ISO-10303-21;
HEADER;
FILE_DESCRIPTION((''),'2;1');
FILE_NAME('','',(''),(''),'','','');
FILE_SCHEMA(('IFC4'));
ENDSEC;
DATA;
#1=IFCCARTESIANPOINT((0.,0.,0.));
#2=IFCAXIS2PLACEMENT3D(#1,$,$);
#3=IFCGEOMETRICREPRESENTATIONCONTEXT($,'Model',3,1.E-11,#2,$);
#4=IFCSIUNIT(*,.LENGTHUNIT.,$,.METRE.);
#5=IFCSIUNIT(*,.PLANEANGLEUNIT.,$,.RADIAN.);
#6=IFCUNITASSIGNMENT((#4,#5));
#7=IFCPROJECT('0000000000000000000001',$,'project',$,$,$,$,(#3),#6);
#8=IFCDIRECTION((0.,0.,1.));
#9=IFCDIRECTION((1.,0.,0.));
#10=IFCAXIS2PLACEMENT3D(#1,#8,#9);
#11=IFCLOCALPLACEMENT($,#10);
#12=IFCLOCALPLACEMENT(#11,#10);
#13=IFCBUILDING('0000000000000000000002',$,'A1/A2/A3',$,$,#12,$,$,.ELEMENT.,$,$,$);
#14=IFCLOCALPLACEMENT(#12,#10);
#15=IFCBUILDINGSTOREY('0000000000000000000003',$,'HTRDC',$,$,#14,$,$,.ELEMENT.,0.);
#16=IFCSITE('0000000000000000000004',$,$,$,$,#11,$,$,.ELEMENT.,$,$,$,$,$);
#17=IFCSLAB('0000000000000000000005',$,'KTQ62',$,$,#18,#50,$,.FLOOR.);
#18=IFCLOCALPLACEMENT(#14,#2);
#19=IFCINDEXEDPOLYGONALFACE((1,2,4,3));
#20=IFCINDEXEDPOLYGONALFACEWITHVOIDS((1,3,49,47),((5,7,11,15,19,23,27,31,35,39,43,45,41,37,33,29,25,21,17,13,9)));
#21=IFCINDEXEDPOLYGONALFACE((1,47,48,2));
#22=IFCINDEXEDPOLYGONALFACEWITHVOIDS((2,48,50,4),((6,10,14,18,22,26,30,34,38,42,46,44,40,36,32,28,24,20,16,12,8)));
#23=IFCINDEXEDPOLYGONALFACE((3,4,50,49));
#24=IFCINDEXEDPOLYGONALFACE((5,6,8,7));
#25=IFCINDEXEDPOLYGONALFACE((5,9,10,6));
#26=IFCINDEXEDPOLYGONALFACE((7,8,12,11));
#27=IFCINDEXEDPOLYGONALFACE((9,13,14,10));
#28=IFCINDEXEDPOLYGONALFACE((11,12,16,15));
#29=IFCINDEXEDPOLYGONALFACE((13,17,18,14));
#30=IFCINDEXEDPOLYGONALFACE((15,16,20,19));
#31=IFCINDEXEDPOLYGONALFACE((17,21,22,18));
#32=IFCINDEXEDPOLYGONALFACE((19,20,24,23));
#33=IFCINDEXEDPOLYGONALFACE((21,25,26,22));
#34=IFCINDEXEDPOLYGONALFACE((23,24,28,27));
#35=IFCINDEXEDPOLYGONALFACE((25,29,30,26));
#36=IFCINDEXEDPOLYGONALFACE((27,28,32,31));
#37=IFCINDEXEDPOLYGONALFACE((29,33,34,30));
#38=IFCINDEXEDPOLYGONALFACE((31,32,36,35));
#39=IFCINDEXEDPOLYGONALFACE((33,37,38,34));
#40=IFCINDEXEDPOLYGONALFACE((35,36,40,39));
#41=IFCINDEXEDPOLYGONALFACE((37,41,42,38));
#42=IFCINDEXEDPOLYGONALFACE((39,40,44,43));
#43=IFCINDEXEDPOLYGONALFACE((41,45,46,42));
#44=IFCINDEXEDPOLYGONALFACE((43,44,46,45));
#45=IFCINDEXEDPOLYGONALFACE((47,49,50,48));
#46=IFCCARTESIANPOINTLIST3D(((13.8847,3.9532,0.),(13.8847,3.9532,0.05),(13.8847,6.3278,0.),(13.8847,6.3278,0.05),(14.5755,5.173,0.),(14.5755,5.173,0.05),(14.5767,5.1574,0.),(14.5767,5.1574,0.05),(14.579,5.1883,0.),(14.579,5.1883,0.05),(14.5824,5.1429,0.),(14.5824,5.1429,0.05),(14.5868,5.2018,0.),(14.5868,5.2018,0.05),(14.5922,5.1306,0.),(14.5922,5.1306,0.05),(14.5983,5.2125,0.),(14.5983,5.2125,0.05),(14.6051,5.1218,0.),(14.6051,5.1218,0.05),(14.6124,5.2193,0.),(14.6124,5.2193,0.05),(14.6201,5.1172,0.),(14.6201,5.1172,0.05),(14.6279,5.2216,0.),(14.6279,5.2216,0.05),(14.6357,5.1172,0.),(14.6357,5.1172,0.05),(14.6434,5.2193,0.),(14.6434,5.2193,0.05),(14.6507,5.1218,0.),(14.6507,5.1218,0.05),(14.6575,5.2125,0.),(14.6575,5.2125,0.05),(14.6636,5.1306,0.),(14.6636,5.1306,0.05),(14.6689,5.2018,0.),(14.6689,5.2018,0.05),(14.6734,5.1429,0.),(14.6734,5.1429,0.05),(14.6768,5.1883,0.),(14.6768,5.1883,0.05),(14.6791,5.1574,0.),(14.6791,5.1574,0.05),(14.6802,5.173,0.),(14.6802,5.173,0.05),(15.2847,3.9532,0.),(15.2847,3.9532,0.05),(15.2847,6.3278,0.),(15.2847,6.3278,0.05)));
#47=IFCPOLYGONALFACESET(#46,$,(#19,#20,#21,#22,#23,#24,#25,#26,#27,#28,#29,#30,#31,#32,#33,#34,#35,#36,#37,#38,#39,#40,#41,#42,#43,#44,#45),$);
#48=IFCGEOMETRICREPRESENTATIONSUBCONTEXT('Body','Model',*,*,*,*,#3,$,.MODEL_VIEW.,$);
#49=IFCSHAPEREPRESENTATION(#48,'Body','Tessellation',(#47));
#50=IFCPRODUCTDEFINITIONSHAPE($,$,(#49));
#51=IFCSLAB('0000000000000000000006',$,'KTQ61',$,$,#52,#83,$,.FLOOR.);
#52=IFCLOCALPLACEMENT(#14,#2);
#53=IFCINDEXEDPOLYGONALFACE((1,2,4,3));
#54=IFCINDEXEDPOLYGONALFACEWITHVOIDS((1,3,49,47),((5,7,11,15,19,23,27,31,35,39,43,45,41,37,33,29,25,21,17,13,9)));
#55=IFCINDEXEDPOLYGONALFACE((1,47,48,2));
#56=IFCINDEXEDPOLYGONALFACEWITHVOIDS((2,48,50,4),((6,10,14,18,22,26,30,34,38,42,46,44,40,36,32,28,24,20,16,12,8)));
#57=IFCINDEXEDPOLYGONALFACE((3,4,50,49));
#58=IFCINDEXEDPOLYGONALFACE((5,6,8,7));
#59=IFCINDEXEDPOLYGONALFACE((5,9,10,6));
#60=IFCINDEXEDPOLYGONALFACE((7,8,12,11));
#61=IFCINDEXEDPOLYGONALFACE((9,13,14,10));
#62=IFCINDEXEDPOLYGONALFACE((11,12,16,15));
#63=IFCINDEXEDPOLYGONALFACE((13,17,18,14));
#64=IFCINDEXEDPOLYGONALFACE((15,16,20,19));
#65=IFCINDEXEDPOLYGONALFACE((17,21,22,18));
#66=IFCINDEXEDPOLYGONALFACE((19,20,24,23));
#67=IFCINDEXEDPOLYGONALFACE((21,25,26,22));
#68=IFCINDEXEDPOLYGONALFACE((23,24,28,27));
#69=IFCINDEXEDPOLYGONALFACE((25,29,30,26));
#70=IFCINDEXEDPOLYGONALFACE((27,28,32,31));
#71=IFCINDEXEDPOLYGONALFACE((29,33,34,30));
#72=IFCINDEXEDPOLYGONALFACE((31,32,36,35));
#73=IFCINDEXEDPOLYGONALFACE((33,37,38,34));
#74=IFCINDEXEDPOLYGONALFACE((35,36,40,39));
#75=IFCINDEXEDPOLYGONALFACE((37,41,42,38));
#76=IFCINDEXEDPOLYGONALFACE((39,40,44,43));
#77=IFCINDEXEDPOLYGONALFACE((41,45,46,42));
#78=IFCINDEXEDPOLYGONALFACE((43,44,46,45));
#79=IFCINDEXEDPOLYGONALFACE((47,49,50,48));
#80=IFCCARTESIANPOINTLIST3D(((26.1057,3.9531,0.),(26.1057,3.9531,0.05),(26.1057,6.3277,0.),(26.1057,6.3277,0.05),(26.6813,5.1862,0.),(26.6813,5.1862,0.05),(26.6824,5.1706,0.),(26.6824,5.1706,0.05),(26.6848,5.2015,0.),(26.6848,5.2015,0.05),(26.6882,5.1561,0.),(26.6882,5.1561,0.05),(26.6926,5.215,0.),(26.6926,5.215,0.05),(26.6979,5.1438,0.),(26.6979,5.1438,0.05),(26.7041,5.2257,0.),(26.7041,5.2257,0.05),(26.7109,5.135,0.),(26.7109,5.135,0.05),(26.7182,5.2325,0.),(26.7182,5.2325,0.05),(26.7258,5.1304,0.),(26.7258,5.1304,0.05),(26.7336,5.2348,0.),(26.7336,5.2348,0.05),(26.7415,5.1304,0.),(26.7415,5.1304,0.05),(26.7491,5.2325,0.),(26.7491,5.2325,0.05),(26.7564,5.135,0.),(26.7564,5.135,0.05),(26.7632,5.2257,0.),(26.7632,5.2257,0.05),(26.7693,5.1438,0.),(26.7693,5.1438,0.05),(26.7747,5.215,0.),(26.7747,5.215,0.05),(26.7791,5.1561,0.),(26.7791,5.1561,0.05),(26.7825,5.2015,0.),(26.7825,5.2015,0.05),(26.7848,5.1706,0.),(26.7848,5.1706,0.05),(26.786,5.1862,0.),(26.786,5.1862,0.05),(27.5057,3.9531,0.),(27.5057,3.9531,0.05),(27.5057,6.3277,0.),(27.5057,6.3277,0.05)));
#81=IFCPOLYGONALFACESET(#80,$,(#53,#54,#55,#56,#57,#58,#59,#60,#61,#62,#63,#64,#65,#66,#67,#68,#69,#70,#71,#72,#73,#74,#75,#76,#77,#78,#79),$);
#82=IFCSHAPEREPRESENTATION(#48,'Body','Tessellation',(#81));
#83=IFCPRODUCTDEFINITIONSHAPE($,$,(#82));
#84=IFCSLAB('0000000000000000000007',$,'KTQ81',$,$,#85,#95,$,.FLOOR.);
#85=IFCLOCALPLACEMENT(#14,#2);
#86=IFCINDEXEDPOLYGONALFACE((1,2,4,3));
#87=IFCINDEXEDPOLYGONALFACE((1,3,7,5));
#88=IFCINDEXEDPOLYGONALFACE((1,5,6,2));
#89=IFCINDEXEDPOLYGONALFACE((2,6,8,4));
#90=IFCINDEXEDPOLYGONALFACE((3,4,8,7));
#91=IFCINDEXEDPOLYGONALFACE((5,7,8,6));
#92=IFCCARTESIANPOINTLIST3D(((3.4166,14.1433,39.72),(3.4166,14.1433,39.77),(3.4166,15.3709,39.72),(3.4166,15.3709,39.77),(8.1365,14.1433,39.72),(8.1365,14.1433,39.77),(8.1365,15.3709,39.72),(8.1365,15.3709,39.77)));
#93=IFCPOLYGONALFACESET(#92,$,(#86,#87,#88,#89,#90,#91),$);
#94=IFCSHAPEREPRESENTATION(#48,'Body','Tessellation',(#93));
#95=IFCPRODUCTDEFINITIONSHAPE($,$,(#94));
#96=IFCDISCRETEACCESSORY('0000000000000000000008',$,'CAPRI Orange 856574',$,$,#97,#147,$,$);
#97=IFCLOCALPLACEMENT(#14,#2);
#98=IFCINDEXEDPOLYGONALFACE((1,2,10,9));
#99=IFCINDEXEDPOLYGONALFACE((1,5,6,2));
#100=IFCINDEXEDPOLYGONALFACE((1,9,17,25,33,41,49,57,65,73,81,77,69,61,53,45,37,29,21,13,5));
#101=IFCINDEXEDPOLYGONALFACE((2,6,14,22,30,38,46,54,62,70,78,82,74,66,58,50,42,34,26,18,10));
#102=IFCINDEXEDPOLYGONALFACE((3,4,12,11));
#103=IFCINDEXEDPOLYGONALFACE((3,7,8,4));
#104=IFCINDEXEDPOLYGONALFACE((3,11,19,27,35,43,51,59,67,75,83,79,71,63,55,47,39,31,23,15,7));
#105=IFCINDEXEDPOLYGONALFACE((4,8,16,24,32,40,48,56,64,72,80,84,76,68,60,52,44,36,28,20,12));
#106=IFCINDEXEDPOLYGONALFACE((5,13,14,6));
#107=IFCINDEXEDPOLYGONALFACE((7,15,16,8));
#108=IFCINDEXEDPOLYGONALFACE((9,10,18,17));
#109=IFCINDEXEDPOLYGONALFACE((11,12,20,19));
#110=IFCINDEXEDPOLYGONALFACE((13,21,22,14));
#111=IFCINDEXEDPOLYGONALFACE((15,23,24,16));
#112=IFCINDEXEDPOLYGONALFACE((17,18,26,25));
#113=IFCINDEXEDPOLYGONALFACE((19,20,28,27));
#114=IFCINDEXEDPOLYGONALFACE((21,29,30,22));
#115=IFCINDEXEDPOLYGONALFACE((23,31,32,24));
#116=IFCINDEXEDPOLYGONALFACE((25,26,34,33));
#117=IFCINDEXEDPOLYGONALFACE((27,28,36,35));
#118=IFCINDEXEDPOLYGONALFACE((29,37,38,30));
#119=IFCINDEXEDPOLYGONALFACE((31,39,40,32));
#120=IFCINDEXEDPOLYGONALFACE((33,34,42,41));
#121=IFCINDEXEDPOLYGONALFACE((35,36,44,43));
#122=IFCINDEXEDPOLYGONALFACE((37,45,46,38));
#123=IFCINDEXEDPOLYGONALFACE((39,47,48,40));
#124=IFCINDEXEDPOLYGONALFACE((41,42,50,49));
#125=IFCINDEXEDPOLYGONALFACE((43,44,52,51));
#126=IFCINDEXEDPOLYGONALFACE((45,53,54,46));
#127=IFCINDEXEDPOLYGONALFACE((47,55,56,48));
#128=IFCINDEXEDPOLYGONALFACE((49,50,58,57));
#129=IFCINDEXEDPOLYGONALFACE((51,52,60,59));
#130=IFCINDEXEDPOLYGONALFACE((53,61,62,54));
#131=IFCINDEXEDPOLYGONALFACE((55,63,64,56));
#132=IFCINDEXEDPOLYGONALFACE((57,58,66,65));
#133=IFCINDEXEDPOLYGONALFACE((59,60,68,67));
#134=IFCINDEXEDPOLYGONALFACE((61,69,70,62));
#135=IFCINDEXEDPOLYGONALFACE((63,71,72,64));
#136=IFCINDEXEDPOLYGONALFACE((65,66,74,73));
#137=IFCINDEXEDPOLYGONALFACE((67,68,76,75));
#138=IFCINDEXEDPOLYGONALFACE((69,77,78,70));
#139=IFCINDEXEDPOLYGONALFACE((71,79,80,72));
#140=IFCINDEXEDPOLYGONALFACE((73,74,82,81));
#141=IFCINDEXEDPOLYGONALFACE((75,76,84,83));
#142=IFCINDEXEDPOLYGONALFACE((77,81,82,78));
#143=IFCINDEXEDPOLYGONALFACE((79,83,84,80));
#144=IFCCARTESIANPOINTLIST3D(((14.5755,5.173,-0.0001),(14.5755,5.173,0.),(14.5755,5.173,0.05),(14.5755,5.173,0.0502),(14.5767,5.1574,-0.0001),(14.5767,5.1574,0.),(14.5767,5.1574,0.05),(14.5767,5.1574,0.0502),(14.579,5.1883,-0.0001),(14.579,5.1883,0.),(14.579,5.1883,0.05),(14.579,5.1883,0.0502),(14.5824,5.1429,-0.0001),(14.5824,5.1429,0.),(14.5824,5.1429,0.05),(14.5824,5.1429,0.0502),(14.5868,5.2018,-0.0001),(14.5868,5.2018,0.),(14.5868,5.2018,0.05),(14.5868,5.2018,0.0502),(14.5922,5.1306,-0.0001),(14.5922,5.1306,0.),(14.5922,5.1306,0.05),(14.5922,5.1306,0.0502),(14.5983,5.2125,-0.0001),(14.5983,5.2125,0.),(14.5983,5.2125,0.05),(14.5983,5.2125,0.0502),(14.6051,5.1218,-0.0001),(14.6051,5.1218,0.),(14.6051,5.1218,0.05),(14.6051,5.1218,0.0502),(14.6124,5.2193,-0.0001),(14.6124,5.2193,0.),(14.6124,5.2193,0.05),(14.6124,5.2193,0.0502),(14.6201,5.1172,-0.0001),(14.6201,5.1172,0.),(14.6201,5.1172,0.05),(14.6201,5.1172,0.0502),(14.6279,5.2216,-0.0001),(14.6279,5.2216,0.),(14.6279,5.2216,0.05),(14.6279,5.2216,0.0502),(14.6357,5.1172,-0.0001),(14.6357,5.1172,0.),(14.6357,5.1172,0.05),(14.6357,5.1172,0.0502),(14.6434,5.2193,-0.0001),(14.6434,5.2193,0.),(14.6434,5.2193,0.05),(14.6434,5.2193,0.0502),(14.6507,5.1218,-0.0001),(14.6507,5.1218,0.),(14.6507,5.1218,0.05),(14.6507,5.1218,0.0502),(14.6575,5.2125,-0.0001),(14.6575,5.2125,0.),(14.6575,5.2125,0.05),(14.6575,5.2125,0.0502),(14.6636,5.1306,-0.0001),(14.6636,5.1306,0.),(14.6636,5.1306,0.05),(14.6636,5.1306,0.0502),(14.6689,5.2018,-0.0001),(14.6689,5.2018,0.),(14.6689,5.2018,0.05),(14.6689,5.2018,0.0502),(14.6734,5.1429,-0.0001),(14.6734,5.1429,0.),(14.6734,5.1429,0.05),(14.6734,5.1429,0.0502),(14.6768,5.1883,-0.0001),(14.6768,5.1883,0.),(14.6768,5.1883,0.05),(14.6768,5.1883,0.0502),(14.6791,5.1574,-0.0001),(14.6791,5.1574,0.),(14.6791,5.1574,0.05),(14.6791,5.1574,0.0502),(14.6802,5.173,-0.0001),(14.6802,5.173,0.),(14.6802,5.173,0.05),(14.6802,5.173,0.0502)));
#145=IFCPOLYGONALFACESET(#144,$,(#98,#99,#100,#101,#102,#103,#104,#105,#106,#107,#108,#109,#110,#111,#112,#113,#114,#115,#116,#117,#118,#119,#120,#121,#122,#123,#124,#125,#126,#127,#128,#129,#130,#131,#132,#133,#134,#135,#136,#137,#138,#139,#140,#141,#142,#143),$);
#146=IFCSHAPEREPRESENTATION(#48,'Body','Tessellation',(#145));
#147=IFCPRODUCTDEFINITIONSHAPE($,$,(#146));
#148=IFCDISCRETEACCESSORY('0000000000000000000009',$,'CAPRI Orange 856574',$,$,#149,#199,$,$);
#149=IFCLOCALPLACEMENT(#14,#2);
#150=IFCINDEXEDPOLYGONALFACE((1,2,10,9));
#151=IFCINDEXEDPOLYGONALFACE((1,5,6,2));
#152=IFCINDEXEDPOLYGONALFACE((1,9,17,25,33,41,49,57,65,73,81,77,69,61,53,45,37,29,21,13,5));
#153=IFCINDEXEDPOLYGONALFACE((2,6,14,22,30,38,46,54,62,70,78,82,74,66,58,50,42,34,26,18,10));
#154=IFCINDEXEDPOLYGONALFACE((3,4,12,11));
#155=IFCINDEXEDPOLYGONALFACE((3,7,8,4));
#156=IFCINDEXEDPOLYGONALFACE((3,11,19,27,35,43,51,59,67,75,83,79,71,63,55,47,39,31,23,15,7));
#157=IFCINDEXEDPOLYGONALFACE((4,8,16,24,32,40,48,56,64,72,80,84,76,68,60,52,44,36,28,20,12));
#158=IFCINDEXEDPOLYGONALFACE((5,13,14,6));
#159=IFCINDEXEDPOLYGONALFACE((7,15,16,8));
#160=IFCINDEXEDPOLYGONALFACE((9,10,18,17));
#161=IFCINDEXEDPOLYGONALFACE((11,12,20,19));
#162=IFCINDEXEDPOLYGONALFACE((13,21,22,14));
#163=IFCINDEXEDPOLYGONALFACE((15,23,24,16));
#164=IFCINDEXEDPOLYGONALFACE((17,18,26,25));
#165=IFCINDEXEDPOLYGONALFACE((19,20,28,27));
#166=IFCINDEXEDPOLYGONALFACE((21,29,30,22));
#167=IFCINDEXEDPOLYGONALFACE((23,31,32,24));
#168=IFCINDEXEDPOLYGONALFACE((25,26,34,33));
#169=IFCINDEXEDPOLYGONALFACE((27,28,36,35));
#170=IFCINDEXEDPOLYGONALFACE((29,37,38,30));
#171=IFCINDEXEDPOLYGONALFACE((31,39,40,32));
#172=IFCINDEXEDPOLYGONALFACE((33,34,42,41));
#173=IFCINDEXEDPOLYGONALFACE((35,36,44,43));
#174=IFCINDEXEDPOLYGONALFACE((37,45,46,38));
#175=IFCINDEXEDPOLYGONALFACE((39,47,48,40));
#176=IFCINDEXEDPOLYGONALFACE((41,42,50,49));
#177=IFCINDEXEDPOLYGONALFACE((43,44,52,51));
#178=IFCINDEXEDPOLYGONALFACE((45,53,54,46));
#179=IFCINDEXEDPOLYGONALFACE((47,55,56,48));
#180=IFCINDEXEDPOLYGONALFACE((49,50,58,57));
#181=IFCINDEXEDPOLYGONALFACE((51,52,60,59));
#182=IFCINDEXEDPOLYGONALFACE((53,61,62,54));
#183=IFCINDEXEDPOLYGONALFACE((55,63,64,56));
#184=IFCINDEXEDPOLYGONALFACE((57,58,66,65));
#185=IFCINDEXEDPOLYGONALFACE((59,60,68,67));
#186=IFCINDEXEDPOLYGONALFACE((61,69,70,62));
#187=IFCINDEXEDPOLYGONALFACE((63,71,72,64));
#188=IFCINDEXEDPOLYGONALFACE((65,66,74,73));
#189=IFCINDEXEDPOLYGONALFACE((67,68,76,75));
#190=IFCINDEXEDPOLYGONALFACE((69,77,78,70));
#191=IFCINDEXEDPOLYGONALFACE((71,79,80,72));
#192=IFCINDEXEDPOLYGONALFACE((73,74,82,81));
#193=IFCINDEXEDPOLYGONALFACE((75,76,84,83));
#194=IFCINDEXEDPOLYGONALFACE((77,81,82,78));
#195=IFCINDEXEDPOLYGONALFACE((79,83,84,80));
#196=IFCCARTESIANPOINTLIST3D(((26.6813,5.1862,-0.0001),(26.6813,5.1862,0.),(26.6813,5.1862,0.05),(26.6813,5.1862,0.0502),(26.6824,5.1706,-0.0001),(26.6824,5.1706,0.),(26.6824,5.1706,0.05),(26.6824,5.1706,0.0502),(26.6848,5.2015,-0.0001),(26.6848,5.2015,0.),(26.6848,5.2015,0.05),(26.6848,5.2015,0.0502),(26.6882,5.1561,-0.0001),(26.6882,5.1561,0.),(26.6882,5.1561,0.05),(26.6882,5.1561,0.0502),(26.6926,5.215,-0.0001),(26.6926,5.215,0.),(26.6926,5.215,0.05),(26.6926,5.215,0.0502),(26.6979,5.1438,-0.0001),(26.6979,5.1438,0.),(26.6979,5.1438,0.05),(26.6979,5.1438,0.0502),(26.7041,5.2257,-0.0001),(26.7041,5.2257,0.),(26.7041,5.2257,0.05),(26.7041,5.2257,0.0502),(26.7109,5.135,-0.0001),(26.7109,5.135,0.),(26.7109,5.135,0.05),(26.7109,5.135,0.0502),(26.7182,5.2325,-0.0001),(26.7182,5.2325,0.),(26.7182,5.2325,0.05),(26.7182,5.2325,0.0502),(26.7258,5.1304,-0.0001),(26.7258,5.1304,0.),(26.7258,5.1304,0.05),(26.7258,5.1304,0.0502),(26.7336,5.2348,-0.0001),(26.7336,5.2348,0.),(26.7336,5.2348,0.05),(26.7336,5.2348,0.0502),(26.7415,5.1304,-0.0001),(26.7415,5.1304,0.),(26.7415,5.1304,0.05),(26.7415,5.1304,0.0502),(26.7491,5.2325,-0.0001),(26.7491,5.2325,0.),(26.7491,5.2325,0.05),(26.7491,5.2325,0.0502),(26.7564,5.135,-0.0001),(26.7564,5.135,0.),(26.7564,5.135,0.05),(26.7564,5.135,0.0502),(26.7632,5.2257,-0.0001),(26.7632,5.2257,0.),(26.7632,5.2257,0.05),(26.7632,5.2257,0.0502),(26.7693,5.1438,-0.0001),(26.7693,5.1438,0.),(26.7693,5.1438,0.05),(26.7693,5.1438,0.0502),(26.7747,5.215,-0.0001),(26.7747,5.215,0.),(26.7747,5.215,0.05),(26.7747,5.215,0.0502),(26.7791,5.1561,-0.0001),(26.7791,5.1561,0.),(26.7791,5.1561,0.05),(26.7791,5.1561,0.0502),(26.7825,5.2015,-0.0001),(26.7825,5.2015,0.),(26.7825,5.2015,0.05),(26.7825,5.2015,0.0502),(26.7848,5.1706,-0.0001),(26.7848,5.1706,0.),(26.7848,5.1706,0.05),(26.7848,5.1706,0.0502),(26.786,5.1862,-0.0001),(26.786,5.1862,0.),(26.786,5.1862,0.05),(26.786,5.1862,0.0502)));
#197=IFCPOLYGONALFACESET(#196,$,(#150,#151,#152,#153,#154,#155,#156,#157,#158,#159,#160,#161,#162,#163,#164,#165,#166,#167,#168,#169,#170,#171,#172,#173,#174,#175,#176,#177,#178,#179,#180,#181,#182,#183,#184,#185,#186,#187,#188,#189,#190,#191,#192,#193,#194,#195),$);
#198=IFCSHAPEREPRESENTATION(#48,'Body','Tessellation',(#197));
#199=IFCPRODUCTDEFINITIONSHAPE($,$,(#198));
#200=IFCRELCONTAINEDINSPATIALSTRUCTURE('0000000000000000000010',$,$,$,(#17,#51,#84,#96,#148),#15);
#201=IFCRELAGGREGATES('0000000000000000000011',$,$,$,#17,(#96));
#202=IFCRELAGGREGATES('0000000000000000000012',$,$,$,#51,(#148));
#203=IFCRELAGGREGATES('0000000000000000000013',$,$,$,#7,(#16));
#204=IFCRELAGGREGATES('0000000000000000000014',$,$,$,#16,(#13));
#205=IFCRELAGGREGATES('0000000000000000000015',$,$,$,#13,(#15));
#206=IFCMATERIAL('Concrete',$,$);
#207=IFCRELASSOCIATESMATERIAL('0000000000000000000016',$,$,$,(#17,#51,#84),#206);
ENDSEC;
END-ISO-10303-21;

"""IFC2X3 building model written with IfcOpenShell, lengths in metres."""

from ifc_helpers import new_model, si_unit, frame, frame_2d, origin, origin_with_axes, origin_2d_with_axis, place, context, subcontext, project, spatial, polyline, circle, outline, extrude, material, element, aggregate, save


model = new_model("IFC2X3")

# Units and contexts
model_context = context("Model", 3, precision=1e-11, world=origin())
body_context = subcontext(model_context, "Body", "Model", "MODEL_VIEW")
ifc_project = project(units=[si_unit("LENGTHUNIT", "METRE"), si_unit("PLANEANGLEUNIT", "RADIAN")], contexts=[model_context])

# Site, building, storey
site_placement = place(None, origin_with_axes())
site = spatial("IfcSite", under=ifc_project, at=site_placement, CompositionType="ELEMENT")
building_placement = place(site_placement, origin_with_axes())
building = spatial("IfcBuilding", under=site, at=building_placement, Name="A1/A2/A3", CompositionType="ELEMENT")
storey_placement = place(building_placement, origin_with_axes())
storey = spatial("IfcBuildingStorey", under=building, at=storey_placement, Name="HTRDC", CompositionType="ELEMENT", Elevation=0.0)

# Shared definitions
ifc_material = material(Name="Concrete")

# Slabs, openings
slab_1_placement = place(storey_placement, frame((13.8847, 3.9532, 0.0), z_axis=(0.0, 0.0, 1.0), x_axis=(1.0, 0.0, 0.0)))
slab_1 = element("IfcSlab", 1, at=slab_1_placement, inside=storey, material=ifc_material, Name="KTQ62", PredefinedType="FLOOR", context=body_context, shape_type="SweptSolid", body=[
    extrude(outline(polyline([(0.0, 0.0), (0.0, -1.4), (2.3746, -1.4), (2.3746, 0.0), (0.0, 0.0)])), frame((0.0, 0.0, 0.0), z_axis=(0.0, 0.0, 1.0), x_axis=(0.0, 1.0, 0.0)), (0.0, 0.0, 1.0), 0.05),
])
opening_1_placement = place(slab_1_placement, frame((0.7432, 1.2159, 0.0), z_axis=(0.0, 0.0, 1.0), x_axis=(1.0, 0.0, 0.0)))
element("IfcOpeningElement", 2, at=opening_1_placement, cuts=slab_1, ObjectType="Opening", context=body_context, shape_type="SweptSolid", body=[
    extrude(circle(Radius=0.0525, at=origin_2d_with_axis()), frame((0.0, 0.0, 0.0), z_axis=(0.0, 0.0, 1.0), x_axis=(0.0, 1.0, 0.0)), (0.0, 0.0, 1.0), 0.05),
])
slab_2_placement = place(storey_placement, frame((26.1057, 3.9531, 0.0), z_axis=(0.0, 0.0, 1.0), x_axis=(1.0, 0.0, 0.0)))
slab_2 = element("IfcSlab", 3, at=slab_2_placement, inside=storey, material=ifc_material, Name="KTQ61", PredefinedType="FLOOR", context=body_context, shape_type="SweptSolid", body=[
    extrude(outline(polyline([(0.0, 0.0), (0.0, -1.4), (2.3746, -1.4), (2.3746, 0.0), (0.0, 0.0)])), frame((0.0, 0.0, 0.0), z_axis=(0.0, 0.0, 1.0), x_axis=(0.0, 1.0, 0.0)), (0.0, 0.0, 1.0), 0.05),
])
opening_2_placement = place(slab_2_placement, frame((0.628, 1.2292, 0.0), z_axis=(0.0, 0.0, 1.0), x_axis=(1.0, 0.0, 0.0)))
element("IfcOpeningElement", 4, at=opening_2_placement, cuts=slab_2, ObjectType="Opening", context=body_context, shape_type="SweptSolid", body=[
    extrude(circle(Radius=0.0525, at=origin_2d_with_axis()), frame((0.0, 0.0, 0.0), z_axis=(0.0, 0.0, 1.0), x_axis=(0.0, 1.0, 0.0)), (0.0, 0.0, 1.0), 0.05),
])

# Slab
for number, where, z_axis, x_axis, name in (
    (5, (3.4166, 14.1433, 39.72), (0.0, 0.0, 1.0), (1.0, 0.0, 0.0), "KTQ81"),
):
    element("IfcSlab", number, at=place(storey_placement, frame(where, z_axis=z_axis, x_axis=x_axis)), inside=storey, material=ifc_material, Name=name, PredefinedType="FLOOR", context=body_context, shape_type="SweptSolid", body=[
        extrude(outline(polyline([(0.0, 0.0), (0.0, -4.72), (1.2275, -4.72), (1.2275, 0.0), (0.0, 0.0)])), frame((0.0, 0.0, 0.0), z_axis=(0.0, 0.0, 1.0), x_axis=(0.0, 1.0, 0.0)), (0.0, 0.0, 1.0), 0.05),
    ])

# Discrete accessories
discrete_accessory_1_placement = place(storey_placement, frame((13.8847, 3.9532, -0.0001), z_axis=(0.0, 0.0, 1.0), x_axis=(1.0, 0.0, 0.0)))
discrete_accessory_1 = element("IfcDiscreteAccessory", 6, at=discrete_accessory_1_placement, inside=storey, Name="CAPRI Orange 856574", context=body_context, shape_type="SweptSolid", body=[
    extrude(circle(Radius=0.0525, at=frame_2d((1.2159, -0.7432), x_axis=(1.0, 0.0))), frame((0.0, 0.0, 0.0), z_axis=(0.0, 0.0, 1.0), x_axis=(0.0, 1.0, 0.0)), (0.0, 0.0, 1.0), 0.0503),
])
aggregate(slab_1, [discrete_accessory_1])
discrete_accessory_2_placement = place(storey_placement, frame((26.1057, 3.9531, -0.0001), z_axis=(0.0, 0.0, 1.0), x_axis=(1.0, 0.0, 0.0)))
discrete_accessory_2 = element("IfcDiscreteAccessory", 7, at=discrete_accessory_2_placement, inside=storey, Name="CAPRI Orange 856574", context=body_context, shape_type="SweptSolid", body=[
    extrude(circle(Radius=0.0525, at=frame_2d((1.2292, -0.628), x_axis=(1.0, 0.0))), frame((0.0, 0.0, 0.0), z_axis=(0.0, 0.0, 1.0), x_axis=(0.0, 1.0, 0.0)), (0.0, 0.0, 1.0), 0.0503),
])
aggregate(slab_2, [discrete_accessory_2])

save(model, "model.ifc")
